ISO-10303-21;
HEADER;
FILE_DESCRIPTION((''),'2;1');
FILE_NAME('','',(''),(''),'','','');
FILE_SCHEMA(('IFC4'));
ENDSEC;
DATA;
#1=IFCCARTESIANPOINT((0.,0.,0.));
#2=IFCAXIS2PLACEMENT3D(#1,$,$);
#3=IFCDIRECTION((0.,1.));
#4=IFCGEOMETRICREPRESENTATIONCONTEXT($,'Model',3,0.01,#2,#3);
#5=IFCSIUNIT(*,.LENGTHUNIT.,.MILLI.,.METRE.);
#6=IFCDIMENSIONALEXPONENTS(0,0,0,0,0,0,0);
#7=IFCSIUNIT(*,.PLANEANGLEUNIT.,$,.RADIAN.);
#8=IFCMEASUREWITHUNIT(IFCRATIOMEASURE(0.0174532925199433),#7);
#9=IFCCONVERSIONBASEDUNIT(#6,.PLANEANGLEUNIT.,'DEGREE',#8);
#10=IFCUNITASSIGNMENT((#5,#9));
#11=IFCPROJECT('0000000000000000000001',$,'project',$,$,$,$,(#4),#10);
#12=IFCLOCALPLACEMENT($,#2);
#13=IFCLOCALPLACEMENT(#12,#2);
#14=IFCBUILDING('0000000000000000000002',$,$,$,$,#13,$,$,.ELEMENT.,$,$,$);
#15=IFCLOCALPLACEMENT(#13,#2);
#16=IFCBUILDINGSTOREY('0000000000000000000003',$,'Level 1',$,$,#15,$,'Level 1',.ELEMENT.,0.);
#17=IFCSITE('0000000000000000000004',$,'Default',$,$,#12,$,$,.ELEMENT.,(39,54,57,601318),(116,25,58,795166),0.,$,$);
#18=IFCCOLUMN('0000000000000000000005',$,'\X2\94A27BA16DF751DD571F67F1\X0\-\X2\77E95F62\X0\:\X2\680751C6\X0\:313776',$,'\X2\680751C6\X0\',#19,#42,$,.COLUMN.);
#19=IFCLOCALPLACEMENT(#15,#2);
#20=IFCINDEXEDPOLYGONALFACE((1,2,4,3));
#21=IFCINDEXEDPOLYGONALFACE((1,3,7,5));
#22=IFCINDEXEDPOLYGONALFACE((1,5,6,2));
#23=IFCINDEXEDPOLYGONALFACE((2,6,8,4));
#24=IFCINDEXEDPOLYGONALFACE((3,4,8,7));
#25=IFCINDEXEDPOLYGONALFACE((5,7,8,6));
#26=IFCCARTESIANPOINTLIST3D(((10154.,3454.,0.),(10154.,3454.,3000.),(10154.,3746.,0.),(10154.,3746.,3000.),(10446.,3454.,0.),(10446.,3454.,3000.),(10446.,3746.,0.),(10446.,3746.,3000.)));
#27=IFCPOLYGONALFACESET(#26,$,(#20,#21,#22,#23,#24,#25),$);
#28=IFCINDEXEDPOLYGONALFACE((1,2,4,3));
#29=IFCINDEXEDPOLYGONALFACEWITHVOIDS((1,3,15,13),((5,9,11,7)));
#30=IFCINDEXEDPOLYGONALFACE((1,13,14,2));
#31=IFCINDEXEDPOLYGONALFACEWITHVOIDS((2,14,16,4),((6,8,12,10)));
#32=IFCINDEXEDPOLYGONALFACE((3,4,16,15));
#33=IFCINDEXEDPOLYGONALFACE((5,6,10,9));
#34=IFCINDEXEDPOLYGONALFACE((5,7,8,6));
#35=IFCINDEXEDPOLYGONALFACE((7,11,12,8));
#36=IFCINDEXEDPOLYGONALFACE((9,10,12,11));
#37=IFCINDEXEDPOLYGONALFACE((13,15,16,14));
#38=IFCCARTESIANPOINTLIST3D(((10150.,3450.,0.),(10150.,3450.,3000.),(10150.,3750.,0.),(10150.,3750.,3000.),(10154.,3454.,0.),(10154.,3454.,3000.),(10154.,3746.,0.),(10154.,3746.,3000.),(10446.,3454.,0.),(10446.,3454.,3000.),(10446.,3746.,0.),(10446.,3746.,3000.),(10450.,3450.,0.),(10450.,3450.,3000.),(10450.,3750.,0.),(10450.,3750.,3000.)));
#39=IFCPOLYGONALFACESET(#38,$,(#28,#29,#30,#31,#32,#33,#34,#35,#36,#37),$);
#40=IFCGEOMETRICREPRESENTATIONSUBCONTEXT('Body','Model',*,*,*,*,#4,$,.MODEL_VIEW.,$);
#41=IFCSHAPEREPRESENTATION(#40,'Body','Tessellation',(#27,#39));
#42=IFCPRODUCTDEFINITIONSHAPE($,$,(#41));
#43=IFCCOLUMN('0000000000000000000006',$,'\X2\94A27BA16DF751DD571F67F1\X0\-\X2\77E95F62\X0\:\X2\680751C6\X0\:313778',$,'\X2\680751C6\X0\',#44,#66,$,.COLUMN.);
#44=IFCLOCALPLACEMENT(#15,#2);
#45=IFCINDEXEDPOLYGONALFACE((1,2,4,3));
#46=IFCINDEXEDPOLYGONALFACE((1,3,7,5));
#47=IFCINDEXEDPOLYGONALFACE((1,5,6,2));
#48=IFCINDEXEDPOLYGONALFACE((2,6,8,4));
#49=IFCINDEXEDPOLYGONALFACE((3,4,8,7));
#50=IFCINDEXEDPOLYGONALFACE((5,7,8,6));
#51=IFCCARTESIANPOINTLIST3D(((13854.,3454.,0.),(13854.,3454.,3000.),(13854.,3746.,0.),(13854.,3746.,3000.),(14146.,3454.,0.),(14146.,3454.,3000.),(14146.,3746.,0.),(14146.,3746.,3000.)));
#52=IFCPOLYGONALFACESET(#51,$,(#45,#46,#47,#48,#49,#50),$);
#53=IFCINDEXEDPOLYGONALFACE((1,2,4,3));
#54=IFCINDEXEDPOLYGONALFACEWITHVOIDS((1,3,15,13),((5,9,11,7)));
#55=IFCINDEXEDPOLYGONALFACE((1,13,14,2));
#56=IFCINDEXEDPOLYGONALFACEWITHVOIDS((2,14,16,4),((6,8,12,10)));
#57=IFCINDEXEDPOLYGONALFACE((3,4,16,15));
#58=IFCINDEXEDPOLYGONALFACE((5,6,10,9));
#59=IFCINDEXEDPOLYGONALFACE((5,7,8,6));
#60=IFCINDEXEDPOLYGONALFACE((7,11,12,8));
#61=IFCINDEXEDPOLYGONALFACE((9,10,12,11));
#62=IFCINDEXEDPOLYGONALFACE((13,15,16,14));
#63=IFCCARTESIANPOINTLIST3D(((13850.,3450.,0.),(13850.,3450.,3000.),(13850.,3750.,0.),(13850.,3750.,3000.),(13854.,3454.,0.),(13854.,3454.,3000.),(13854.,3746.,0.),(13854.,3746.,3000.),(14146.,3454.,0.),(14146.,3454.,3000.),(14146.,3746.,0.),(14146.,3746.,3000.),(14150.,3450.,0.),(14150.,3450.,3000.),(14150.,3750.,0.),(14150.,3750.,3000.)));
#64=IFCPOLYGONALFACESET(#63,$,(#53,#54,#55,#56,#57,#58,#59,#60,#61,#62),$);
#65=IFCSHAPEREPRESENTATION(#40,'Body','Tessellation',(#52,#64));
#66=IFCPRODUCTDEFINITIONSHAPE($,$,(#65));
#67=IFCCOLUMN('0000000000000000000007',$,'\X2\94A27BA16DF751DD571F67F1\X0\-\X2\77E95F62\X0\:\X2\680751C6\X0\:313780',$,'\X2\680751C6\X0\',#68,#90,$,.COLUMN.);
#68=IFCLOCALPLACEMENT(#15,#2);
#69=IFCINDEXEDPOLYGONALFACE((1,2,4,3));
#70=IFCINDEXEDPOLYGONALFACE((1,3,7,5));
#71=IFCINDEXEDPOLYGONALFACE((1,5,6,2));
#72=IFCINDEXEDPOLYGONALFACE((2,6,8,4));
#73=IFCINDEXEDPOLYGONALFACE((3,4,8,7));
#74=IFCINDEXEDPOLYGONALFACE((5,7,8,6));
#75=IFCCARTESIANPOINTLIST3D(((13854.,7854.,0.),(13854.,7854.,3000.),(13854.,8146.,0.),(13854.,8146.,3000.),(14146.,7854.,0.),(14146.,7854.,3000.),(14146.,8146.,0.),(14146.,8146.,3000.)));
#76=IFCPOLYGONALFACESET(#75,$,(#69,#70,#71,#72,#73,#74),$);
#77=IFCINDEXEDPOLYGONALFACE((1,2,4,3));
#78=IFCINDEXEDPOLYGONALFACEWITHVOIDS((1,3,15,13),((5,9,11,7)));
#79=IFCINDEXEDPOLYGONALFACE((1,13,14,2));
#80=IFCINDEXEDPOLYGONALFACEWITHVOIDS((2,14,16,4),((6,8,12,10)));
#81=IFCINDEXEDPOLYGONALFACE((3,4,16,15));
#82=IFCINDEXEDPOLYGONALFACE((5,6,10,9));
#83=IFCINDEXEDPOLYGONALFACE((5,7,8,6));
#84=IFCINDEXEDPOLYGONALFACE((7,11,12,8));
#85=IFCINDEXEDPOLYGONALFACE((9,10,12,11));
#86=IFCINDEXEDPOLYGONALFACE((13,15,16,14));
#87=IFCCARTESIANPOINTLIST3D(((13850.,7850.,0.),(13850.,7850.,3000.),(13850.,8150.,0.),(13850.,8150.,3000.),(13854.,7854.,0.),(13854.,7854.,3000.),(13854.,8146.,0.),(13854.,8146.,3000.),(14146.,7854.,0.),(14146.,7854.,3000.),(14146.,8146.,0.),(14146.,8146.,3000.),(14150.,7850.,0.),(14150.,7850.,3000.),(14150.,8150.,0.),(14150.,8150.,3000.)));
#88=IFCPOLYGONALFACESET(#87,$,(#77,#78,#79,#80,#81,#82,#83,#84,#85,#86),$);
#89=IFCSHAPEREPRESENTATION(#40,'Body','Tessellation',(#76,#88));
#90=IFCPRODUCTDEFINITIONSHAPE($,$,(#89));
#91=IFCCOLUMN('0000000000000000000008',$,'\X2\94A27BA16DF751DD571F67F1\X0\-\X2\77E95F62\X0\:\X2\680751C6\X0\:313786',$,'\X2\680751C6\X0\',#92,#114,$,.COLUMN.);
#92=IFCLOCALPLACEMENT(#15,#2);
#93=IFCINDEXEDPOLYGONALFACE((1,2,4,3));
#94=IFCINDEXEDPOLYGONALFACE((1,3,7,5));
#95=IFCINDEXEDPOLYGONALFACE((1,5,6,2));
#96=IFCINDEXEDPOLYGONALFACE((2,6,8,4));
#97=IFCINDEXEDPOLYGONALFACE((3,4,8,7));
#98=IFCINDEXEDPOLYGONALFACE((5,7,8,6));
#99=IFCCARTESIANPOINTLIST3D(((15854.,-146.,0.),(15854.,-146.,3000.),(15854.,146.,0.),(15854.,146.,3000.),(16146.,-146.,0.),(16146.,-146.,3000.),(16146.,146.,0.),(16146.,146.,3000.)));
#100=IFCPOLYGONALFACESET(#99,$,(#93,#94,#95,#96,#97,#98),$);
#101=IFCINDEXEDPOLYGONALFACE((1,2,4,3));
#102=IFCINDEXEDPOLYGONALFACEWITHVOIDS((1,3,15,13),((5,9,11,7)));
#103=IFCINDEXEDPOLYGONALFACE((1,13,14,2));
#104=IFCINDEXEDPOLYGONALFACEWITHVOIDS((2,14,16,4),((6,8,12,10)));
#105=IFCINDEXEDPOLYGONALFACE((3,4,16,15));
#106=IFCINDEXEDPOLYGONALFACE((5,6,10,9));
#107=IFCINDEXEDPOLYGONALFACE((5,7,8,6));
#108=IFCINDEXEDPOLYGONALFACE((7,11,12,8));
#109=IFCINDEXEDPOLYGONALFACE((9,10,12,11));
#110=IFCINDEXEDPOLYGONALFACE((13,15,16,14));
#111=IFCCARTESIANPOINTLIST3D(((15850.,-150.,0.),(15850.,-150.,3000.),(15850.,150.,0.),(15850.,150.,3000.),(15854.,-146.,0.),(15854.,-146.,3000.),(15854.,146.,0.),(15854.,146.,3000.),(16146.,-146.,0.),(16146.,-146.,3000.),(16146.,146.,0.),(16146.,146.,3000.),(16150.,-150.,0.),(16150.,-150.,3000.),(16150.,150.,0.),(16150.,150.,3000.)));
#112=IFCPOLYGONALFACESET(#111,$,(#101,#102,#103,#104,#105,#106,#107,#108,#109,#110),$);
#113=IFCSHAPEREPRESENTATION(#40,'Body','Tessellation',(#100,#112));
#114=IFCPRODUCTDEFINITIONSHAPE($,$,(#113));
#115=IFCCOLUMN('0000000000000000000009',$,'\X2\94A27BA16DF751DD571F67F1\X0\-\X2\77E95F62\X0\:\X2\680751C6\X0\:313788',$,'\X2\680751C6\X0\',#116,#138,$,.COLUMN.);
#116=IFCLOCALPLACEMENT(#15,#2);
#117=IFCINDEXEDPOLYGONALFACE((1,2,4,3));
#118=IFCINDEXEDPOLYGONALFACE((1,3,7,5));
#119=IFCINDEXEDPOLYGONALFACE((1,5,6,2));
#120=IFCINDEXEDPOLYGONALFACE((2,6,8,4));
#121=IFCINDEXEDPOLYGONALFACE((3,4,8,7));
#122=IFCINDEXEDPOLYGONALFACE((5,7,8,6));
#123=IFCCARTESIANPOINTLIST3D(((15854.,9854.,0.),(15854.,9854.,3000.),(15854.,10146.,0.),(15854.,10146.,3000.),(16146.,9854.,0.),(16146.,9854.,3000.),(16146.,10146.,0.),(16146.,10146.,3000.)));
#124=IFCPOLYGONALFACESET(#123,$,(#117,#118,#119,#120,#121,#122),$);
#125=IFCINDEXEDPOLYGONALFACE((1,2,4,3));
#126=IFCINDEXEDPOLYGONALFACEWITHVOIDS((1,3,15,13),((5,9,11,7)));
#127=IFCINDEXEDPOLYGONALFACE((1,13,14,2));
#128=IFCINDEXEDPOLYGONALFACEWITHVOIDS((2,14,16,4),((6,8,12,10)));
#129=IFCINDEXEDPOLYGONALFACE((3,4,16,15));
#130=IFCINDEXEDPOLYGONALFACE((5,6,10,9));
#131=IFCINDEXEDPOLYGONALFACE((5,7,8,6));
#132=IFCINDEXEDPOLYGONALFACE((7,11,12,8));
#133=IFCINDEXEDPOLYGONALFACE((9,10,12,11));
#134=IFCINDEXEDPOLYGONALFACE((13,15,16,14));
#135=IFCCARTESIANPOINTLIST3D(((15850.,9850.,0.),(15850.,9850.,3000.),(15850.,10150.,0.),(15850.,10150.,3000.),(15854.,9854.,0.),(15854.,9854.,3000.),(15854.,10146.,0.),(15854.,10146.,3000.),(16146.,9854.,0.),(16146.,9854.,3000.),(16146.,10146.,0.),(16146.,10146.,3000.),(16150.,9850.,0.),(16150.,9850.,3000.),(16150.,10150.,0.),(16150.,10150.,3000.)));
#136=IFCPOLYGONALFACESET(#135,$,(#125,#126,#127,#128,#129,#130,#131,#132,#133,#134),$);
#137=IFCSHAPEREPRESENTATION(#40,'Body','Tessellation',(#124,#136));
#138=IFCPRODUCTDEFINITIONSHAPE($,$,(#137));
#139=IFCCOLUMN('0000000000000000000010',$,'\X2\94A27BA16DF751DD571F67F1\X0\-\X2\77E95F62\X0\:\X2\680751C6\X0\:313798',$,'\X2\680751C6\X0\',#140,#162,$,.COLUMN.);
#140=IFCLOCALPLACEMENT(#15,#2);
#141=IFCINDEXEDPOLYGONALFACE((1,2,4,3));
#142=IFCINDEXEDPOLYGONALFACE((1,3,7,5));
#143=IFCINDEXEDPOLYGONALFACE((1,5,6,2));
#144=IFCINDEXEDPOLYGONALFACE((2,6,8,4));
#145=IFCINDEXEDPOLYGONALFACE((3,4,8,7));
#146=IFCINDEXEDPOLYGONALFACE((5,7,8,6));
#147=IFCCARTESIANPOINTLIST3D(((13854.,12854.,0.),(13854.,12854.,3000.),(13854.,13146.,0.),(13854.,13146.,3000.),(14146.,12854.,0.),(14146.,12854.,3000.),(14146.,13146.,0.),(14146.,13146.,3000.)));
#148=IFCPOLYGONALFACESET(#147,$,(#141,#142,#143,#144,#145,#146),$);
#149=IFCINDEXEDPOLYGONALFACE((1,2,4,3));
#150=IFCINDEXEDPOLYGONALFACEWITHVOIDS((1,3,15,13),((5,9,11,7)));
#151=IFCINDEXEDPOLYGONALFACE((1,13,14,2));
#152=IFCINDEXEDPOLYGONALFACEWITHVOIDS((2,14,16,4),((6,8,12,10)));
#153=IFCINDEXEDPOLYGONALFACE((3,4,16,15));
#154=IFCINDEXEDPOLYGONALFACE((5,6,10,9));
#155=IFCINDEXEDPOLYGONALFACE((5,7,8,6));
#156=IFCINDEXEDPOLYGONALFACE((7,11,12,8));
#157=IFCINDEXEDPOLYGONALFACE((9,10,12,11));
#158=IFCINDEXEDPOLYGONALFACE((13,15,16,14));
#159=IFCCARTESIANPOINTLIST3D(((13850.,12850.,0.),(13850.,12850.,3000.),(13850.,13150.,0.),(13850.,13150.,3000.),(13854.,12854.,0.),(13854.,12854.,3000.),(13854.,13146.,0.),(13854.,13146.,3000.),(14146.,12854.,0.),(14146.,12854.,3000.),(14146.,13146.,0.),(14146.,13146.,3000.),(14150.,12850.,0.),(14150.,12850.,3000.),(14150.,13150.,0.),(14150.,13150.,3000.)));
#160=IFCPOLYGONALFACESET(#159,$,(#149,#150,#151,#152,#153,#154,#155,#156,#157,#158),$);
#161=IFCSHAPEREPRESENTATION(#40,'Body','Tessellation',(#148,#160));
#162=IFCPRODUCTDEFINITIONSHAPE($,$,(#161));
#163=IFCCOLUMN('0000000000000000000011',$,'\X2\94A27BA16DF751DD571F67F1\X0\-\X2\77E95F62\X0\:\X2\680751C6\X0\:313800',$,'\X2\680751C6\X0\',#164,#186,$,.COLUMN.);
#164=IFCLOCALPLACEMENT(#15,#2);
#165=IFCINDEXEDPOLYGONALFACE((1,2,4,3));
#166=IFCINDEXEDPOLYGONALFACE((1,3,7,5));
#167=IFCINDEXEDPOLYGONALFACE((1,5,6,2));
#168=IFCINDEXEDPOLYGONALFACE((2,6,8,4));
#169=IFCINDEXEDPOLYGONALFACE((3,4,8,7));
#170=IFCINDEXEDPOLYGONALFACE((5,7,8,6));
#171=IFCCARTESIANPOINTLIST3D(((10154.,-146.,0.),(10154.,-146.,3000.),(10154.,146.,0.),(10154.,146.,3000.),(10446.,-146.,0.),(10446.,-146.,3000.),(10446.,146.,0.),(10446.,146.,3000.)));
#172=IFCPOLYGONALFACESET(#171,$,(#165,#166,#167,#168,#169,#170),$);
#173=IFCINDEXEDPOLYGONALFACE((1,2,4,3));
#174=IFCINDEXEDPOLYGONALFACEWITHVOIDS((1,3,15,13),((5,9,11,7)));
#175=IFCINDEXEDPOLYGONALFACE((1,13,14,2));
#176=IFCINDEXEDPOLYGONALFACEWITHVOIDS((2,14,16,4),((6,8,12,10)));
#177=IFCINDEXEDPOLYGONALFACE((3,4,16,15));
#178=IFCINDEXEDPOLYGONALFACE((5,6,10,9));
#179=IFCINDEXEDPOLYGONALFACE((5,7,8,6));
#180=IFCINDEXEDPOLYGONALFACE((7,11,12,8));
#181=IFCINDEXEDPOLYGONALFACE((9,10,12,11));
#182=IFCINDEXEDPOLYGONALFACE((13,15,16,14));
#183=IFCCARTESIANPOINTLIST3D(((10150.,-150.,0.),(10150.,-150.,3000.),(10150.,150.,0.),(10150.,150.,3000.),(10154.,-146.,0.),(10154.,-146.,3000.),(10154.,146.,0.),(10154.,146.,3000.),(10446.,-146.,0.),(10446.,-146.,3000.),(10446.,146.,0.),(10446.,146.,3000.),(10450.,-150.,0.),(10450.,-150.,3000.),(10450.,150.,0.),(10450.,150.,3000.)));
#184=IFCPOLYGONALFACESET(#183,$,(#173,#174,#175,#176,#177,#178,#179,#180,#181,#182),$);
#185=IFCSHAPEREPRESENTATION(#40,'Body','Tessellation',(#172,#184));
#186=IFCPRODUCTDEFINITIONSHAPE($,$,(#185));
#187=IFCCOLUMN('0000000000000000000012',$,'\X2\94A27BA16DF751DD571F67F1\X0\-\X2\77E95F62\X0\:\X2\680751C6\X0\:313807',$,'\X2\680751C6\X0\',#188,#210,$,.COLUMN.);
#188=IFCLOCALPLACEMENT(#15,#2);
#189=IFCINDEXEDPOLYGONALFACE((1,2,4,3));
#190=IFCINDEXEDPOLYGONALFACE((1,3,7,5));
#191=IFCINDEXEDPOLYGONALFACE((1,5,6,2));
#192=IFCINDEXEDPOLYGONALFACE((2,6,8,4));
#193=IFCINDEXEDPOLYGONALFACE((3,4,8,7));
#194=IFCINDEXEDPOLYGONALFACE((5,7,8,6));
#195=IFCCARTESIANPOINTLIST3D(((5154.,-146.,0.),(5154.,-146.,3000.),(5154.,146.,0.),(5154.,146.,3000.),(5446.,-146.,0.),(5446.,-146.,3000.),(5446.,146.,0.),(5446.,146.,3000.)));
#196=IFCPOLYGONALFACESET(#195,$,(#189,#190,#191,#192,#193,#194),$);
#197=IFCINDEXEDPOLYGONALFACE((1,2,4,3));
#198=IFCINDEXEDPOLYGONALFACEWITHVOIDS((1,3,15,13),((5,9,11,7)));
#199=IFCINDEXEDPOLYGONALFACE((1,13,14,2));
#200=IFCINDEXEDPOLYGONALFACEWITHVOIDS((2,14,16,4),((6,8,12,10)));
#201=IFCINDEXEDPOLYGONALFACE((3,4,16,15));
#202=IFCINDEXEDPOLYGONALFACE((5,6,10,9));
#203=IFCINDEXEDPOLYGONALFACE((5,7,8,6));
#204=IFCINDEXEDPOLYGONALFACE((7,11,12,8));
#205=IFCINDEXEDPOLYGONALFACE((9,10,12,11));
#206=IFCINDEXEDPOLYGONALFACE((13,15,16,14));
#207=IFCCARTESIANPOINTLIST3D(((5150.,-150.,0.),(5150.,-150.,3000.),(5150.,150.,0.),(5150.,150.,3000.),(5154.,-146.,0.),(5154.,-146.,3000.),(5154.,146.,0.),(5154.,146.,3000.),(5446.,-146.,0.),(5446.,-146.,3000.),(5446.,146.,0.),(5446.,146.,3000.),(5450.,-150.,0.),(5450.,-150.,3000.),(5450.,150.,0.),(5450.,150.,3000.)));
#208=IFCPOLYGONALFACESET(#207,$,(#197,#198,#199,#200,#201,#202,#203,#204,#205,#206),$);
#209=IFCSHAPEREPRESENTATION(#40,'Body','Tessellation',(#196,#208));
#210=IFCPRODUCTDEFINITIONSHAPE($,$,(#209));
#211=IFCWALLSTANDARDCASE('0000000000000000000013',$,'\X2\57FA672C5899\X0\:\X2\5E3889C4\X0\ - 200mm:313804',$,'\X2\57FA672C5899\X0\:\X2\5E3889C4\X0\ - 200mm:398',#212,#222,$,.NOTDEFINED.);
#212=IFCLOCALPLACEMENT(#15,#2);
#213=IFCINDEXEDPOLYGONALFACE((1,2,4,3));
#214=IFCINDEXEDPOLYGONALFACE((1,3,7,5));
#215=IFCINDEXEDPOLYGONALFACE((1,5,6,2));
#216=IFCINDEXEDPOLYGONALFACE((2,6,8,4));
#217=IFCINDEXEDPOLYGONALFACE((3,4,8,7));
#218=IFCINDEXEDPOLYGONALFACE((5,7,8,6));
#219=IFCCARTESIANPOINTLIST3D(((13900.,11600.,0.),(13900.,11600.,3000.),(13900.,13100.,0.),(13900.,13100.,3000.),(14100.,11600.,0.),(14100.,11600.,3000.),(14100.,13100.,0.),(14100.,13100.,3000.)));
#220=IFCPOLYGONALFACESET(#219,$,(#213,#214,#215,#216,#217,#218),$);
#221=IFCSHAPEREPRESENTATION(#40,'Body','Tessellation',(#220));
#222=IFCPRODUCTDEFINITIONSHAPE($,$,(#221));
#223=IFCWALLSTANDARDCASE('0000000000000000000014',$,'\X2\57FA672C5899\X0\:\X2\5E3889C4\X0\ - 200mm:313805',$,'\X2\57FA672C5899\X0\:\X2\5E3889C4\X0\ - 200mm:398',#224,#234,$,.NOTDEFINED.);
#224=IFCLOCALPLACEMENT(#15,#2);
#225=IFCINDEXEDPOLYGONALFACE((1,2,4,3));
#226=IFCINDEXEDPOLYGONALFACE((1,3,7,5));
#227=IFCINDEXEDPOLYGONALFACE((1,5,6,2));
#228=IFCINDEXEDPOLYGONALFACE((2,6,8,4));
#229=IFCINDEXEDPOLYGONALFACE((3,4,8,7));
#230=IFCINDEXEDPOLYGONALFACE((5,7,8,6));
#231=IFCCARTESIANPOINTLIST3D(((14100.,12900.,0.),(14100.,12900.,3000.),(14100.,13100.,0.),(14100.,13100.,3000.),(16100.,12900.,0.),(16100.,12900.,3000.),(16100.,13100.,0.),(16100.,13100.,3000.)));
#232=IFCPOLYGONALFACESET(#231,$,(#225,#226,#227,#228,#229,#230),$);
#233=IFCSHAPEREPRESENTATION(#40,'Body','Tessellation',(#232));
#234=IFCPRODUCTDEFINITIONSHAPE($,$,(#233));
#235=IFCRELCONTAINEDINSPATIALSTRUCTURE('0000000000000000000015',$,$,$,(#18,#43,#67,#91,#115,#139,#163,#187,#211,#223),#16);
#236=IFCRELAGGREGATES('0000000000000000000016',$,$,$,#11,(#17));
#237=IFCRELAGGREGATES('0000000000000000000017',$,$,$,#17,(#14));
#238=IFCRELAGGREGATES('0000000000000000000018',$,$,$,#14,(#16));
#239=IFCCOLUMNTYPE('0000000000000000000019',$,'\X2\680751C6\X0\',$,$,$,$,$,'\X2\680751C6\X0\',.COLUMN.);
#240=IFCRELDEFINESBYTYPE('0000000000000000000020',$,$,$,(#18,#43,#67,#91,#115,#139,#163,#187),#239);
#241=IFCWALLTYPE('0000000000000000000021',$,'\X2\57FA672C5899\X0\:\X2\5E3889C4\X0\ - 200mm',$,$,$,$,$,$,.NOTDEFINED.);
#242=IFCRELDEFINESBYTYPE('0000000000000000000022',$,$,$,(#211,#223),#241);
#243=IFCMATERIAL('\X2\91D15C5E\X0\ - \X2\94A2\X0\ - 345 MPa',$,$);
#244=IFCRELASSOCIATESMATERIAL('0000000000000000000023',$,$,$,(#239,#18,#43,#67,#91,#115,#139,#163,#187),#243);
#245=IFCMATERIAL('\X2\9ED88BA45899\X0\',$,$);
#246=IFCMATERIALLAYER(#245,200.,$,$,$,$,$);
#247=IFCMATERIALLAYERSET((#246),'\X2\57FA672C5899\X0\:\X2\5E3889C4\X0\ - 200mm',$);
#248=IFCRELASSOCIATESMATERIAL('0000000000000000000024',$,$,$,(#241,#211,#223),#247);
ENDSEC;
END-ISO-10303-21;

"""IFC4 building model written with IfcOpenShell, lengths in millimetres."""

from ifc_helpers import new_model, entity, si_unit, converted_unit, direction, frame, frame_2d, origin, origin_2d_with_axis, place, context, subcontext, project, spatial, polyline, rectangle, outline, extrude, source, transform, mapped, material, layer, layer_set, layer_usage, type_object, type_shapes, element, save


model = new_model("IFC4")

# Units and contexts
model_context_1 = context("Model", 3, precision=0.01, world=origin(), true_north=direction((0.0, 1.0)))
body_context_1 = subcontext(model_context_1, "Body", "Model", "MODEL_VIEW")
ifc_project = project(units=[si_unit("LENGTHUNIT", "METRE", prefix="MILLI"), converted_unit("PLANEANGLEUNIT", "DEGREE", entity("IfcRatioMeasure", 0.0174532925199433), si_unit("PLANEANGLEUNIT", "RADIAN"), dimensions=[0, 0, 0, 0, 0, 0, 0])], contexts=[model_context_1])

# Site, building, storey
site_placement = place(None, origin())
site = spatial("IfcSite", under=ifc_project, at=site_placement, Name="Default", CompositionType="ELEMENT", RefLatitude=(39, 54, 57, 601318), RefLongitude=(116, 25, 58, 795166), RefElevation=0.0)
building_placement = place(site_placement, origin())
building = spatial("IfcBuilding", under=site, at=building_placement, CompositionType="ELEMENT")
storey_placement = place(building_placement, origin())
storey = spatial("IfcBuildingStorey", under=building, at=storey_placement, Name="Level 1", LongName="Level 1", CompositionType="ELEMENT", Elevation=0.0)

# Columns
ifc_material_1 = material(Name="金属 - 钢 - 345 MPa")
column_type = type_object("IfcColumnType", Name="标准", ElementType="标准", PredefinedType="COLUMN", material=ifc_material_1)
shared_shape_1 = source(origin(), body_context_1, "Body", "SweptSolid", [
    extrude(rectangle(XDim=292.0, YDim=292.0, at=origin_2d_with_axis()), frame((0.0, 0.0, 0.0), z_axis=(0.0, 0.0, 1.0), x_axis=(-1.0, 0.0, 0.0)), (0.0, 0.0, 1.0), 3000.0),
    extrude(outline(polyline([(-150.0, -150.0), (150.0, -150.0), (150.0, 150.0), (-150.0, 150.0), (-150.0, -150.0)]), holes=[polyline([(-146.0, -146.0), (-146.0, 146.0), (146.0, 146.0), (146.0, -146.0), (-146.0, -146.0)])]), frame((0.0, 0.0, 0.0), z_axis=(0.0, 0.0, 1.0), x_axis=(-1.0, 0.0, 0.0)), (0.0, 0.0, 1.0), 3000.0),
])
type_shapes(column_type, [shared_shape_1])
for number, where, name in (
    (1, (10300.0, 3600.0, 0.0), "钢管混凝土柱-矩形:标准:313776"),
    (2, (14000.0, 3600.0, 0.0), "钢管混凝土柱-矩形:标准:313778"),
    (3, (14000.0, 8000.0, 0.0), "钢管混凝土柱-矩形:标准:313780"),
    (4, (16000.0, 0.0, 0.0), "钢管混凝土柱-矩形:标准:313786"),
    (5, (16000.0, 10000.0, 0.0), "钢管混凝土柱-矩形:标准:313788"),
    (6, (14000.0, 13000.0, 0.0), "钢管混凝土柱-矩形:标准:313798"),
    (7, (10300.0, 0.0, 0.0), "钢管混凝土柱-矩形:标准:313800"),
    (8, (5300.0, 0.0, 0.0), "钢管混凝土柱-矩形:标准:313807"),
):
    element("IfcColumn", number, at=place(storey_placement, frame(where)), inside=storey, type_object=column_type, material=ifc_material_1, Name=name, ObjectType="标准", PredefinedType="COLUMN", context=body_context_1, shape_type="MappedRepresentation", body=[
        mapped(shared_shape_1, transform((0.0, 0.0, 0.0), scale=1.0)),
    ])

# Shared definitions
ifc_material_2 = material(Name="默认墙")
ifc_layer_1 = layer(ifc_material_2, 200.0)
ifc_layer_set_1 = layer_set([ifc_layer_1], Name="基本墙:常规 - 200mm")
wall_type_1 = type_object("IfcWallType", Name="基本墙:常规 - 200mm", PredefinedType="NOTDEFINED", material=ifc_layer_set_1)

# Walls
ifc_layer_usage_1 = layer_usage(ifc_layer_set_1, "AXIS2", "NEGATIVE", 100.0)
wall_1_placement = place(storey_placement, frame((14000.0, 11600.0, 0.0), z_axis=(0.0, 0.0, 1.0), x_axis=(0.0, 1.0, 0.0)))
element("IfcWallStandardCase", 9, at=wall_1_placement, inside=storey, type_object=wall_type_1, material=ifc_layer_usage_1, Name="基本墙:常规 - 200mm:313804", ObjectType="基本墙:常规 - 200mm:398", PredefinedType="NOTDEFINED", context=body_context_1, shape_type="SweptSolid", body=[
    extrude(rectangle(XDim=1500.0, YDim=200.0, at=frame_2d((750.0, 0.0), x_axis=(-1.0, 0.0))), origin(), (0.0, 0.0, 1.0), 3000.0),
])
ifc_layer_usage_2 = layer_usage(ifc_layer_set_1, "AXIS2", "NEGATIVE", 100.0)
wall_2_placement = place(storey_placement, frame((14100.0, 13000.0, 0.0)))
element("IfcWallStandardCase", 10, at=wall_2_placement, inside=storey, type_object=wall_type_1, material=ifc_layer_usage_2, Name="基本墙:常规 - 200mm:313805", ObjectType="基本墙:常规 - 200mm:398", PredefinedType="NOTDEFINED", context=body_context_1, shape_type="SweptSolid", body=[
    extrude(rectangle(XDim=2000.0, YDim=200.0, at=frame_2d((1000.0, 0.0), x_axis=(-1.0, 0.0))), origin(), (0.0, 0.0, 1.0), 3000.0),
])

save(model, "model.ifc")
